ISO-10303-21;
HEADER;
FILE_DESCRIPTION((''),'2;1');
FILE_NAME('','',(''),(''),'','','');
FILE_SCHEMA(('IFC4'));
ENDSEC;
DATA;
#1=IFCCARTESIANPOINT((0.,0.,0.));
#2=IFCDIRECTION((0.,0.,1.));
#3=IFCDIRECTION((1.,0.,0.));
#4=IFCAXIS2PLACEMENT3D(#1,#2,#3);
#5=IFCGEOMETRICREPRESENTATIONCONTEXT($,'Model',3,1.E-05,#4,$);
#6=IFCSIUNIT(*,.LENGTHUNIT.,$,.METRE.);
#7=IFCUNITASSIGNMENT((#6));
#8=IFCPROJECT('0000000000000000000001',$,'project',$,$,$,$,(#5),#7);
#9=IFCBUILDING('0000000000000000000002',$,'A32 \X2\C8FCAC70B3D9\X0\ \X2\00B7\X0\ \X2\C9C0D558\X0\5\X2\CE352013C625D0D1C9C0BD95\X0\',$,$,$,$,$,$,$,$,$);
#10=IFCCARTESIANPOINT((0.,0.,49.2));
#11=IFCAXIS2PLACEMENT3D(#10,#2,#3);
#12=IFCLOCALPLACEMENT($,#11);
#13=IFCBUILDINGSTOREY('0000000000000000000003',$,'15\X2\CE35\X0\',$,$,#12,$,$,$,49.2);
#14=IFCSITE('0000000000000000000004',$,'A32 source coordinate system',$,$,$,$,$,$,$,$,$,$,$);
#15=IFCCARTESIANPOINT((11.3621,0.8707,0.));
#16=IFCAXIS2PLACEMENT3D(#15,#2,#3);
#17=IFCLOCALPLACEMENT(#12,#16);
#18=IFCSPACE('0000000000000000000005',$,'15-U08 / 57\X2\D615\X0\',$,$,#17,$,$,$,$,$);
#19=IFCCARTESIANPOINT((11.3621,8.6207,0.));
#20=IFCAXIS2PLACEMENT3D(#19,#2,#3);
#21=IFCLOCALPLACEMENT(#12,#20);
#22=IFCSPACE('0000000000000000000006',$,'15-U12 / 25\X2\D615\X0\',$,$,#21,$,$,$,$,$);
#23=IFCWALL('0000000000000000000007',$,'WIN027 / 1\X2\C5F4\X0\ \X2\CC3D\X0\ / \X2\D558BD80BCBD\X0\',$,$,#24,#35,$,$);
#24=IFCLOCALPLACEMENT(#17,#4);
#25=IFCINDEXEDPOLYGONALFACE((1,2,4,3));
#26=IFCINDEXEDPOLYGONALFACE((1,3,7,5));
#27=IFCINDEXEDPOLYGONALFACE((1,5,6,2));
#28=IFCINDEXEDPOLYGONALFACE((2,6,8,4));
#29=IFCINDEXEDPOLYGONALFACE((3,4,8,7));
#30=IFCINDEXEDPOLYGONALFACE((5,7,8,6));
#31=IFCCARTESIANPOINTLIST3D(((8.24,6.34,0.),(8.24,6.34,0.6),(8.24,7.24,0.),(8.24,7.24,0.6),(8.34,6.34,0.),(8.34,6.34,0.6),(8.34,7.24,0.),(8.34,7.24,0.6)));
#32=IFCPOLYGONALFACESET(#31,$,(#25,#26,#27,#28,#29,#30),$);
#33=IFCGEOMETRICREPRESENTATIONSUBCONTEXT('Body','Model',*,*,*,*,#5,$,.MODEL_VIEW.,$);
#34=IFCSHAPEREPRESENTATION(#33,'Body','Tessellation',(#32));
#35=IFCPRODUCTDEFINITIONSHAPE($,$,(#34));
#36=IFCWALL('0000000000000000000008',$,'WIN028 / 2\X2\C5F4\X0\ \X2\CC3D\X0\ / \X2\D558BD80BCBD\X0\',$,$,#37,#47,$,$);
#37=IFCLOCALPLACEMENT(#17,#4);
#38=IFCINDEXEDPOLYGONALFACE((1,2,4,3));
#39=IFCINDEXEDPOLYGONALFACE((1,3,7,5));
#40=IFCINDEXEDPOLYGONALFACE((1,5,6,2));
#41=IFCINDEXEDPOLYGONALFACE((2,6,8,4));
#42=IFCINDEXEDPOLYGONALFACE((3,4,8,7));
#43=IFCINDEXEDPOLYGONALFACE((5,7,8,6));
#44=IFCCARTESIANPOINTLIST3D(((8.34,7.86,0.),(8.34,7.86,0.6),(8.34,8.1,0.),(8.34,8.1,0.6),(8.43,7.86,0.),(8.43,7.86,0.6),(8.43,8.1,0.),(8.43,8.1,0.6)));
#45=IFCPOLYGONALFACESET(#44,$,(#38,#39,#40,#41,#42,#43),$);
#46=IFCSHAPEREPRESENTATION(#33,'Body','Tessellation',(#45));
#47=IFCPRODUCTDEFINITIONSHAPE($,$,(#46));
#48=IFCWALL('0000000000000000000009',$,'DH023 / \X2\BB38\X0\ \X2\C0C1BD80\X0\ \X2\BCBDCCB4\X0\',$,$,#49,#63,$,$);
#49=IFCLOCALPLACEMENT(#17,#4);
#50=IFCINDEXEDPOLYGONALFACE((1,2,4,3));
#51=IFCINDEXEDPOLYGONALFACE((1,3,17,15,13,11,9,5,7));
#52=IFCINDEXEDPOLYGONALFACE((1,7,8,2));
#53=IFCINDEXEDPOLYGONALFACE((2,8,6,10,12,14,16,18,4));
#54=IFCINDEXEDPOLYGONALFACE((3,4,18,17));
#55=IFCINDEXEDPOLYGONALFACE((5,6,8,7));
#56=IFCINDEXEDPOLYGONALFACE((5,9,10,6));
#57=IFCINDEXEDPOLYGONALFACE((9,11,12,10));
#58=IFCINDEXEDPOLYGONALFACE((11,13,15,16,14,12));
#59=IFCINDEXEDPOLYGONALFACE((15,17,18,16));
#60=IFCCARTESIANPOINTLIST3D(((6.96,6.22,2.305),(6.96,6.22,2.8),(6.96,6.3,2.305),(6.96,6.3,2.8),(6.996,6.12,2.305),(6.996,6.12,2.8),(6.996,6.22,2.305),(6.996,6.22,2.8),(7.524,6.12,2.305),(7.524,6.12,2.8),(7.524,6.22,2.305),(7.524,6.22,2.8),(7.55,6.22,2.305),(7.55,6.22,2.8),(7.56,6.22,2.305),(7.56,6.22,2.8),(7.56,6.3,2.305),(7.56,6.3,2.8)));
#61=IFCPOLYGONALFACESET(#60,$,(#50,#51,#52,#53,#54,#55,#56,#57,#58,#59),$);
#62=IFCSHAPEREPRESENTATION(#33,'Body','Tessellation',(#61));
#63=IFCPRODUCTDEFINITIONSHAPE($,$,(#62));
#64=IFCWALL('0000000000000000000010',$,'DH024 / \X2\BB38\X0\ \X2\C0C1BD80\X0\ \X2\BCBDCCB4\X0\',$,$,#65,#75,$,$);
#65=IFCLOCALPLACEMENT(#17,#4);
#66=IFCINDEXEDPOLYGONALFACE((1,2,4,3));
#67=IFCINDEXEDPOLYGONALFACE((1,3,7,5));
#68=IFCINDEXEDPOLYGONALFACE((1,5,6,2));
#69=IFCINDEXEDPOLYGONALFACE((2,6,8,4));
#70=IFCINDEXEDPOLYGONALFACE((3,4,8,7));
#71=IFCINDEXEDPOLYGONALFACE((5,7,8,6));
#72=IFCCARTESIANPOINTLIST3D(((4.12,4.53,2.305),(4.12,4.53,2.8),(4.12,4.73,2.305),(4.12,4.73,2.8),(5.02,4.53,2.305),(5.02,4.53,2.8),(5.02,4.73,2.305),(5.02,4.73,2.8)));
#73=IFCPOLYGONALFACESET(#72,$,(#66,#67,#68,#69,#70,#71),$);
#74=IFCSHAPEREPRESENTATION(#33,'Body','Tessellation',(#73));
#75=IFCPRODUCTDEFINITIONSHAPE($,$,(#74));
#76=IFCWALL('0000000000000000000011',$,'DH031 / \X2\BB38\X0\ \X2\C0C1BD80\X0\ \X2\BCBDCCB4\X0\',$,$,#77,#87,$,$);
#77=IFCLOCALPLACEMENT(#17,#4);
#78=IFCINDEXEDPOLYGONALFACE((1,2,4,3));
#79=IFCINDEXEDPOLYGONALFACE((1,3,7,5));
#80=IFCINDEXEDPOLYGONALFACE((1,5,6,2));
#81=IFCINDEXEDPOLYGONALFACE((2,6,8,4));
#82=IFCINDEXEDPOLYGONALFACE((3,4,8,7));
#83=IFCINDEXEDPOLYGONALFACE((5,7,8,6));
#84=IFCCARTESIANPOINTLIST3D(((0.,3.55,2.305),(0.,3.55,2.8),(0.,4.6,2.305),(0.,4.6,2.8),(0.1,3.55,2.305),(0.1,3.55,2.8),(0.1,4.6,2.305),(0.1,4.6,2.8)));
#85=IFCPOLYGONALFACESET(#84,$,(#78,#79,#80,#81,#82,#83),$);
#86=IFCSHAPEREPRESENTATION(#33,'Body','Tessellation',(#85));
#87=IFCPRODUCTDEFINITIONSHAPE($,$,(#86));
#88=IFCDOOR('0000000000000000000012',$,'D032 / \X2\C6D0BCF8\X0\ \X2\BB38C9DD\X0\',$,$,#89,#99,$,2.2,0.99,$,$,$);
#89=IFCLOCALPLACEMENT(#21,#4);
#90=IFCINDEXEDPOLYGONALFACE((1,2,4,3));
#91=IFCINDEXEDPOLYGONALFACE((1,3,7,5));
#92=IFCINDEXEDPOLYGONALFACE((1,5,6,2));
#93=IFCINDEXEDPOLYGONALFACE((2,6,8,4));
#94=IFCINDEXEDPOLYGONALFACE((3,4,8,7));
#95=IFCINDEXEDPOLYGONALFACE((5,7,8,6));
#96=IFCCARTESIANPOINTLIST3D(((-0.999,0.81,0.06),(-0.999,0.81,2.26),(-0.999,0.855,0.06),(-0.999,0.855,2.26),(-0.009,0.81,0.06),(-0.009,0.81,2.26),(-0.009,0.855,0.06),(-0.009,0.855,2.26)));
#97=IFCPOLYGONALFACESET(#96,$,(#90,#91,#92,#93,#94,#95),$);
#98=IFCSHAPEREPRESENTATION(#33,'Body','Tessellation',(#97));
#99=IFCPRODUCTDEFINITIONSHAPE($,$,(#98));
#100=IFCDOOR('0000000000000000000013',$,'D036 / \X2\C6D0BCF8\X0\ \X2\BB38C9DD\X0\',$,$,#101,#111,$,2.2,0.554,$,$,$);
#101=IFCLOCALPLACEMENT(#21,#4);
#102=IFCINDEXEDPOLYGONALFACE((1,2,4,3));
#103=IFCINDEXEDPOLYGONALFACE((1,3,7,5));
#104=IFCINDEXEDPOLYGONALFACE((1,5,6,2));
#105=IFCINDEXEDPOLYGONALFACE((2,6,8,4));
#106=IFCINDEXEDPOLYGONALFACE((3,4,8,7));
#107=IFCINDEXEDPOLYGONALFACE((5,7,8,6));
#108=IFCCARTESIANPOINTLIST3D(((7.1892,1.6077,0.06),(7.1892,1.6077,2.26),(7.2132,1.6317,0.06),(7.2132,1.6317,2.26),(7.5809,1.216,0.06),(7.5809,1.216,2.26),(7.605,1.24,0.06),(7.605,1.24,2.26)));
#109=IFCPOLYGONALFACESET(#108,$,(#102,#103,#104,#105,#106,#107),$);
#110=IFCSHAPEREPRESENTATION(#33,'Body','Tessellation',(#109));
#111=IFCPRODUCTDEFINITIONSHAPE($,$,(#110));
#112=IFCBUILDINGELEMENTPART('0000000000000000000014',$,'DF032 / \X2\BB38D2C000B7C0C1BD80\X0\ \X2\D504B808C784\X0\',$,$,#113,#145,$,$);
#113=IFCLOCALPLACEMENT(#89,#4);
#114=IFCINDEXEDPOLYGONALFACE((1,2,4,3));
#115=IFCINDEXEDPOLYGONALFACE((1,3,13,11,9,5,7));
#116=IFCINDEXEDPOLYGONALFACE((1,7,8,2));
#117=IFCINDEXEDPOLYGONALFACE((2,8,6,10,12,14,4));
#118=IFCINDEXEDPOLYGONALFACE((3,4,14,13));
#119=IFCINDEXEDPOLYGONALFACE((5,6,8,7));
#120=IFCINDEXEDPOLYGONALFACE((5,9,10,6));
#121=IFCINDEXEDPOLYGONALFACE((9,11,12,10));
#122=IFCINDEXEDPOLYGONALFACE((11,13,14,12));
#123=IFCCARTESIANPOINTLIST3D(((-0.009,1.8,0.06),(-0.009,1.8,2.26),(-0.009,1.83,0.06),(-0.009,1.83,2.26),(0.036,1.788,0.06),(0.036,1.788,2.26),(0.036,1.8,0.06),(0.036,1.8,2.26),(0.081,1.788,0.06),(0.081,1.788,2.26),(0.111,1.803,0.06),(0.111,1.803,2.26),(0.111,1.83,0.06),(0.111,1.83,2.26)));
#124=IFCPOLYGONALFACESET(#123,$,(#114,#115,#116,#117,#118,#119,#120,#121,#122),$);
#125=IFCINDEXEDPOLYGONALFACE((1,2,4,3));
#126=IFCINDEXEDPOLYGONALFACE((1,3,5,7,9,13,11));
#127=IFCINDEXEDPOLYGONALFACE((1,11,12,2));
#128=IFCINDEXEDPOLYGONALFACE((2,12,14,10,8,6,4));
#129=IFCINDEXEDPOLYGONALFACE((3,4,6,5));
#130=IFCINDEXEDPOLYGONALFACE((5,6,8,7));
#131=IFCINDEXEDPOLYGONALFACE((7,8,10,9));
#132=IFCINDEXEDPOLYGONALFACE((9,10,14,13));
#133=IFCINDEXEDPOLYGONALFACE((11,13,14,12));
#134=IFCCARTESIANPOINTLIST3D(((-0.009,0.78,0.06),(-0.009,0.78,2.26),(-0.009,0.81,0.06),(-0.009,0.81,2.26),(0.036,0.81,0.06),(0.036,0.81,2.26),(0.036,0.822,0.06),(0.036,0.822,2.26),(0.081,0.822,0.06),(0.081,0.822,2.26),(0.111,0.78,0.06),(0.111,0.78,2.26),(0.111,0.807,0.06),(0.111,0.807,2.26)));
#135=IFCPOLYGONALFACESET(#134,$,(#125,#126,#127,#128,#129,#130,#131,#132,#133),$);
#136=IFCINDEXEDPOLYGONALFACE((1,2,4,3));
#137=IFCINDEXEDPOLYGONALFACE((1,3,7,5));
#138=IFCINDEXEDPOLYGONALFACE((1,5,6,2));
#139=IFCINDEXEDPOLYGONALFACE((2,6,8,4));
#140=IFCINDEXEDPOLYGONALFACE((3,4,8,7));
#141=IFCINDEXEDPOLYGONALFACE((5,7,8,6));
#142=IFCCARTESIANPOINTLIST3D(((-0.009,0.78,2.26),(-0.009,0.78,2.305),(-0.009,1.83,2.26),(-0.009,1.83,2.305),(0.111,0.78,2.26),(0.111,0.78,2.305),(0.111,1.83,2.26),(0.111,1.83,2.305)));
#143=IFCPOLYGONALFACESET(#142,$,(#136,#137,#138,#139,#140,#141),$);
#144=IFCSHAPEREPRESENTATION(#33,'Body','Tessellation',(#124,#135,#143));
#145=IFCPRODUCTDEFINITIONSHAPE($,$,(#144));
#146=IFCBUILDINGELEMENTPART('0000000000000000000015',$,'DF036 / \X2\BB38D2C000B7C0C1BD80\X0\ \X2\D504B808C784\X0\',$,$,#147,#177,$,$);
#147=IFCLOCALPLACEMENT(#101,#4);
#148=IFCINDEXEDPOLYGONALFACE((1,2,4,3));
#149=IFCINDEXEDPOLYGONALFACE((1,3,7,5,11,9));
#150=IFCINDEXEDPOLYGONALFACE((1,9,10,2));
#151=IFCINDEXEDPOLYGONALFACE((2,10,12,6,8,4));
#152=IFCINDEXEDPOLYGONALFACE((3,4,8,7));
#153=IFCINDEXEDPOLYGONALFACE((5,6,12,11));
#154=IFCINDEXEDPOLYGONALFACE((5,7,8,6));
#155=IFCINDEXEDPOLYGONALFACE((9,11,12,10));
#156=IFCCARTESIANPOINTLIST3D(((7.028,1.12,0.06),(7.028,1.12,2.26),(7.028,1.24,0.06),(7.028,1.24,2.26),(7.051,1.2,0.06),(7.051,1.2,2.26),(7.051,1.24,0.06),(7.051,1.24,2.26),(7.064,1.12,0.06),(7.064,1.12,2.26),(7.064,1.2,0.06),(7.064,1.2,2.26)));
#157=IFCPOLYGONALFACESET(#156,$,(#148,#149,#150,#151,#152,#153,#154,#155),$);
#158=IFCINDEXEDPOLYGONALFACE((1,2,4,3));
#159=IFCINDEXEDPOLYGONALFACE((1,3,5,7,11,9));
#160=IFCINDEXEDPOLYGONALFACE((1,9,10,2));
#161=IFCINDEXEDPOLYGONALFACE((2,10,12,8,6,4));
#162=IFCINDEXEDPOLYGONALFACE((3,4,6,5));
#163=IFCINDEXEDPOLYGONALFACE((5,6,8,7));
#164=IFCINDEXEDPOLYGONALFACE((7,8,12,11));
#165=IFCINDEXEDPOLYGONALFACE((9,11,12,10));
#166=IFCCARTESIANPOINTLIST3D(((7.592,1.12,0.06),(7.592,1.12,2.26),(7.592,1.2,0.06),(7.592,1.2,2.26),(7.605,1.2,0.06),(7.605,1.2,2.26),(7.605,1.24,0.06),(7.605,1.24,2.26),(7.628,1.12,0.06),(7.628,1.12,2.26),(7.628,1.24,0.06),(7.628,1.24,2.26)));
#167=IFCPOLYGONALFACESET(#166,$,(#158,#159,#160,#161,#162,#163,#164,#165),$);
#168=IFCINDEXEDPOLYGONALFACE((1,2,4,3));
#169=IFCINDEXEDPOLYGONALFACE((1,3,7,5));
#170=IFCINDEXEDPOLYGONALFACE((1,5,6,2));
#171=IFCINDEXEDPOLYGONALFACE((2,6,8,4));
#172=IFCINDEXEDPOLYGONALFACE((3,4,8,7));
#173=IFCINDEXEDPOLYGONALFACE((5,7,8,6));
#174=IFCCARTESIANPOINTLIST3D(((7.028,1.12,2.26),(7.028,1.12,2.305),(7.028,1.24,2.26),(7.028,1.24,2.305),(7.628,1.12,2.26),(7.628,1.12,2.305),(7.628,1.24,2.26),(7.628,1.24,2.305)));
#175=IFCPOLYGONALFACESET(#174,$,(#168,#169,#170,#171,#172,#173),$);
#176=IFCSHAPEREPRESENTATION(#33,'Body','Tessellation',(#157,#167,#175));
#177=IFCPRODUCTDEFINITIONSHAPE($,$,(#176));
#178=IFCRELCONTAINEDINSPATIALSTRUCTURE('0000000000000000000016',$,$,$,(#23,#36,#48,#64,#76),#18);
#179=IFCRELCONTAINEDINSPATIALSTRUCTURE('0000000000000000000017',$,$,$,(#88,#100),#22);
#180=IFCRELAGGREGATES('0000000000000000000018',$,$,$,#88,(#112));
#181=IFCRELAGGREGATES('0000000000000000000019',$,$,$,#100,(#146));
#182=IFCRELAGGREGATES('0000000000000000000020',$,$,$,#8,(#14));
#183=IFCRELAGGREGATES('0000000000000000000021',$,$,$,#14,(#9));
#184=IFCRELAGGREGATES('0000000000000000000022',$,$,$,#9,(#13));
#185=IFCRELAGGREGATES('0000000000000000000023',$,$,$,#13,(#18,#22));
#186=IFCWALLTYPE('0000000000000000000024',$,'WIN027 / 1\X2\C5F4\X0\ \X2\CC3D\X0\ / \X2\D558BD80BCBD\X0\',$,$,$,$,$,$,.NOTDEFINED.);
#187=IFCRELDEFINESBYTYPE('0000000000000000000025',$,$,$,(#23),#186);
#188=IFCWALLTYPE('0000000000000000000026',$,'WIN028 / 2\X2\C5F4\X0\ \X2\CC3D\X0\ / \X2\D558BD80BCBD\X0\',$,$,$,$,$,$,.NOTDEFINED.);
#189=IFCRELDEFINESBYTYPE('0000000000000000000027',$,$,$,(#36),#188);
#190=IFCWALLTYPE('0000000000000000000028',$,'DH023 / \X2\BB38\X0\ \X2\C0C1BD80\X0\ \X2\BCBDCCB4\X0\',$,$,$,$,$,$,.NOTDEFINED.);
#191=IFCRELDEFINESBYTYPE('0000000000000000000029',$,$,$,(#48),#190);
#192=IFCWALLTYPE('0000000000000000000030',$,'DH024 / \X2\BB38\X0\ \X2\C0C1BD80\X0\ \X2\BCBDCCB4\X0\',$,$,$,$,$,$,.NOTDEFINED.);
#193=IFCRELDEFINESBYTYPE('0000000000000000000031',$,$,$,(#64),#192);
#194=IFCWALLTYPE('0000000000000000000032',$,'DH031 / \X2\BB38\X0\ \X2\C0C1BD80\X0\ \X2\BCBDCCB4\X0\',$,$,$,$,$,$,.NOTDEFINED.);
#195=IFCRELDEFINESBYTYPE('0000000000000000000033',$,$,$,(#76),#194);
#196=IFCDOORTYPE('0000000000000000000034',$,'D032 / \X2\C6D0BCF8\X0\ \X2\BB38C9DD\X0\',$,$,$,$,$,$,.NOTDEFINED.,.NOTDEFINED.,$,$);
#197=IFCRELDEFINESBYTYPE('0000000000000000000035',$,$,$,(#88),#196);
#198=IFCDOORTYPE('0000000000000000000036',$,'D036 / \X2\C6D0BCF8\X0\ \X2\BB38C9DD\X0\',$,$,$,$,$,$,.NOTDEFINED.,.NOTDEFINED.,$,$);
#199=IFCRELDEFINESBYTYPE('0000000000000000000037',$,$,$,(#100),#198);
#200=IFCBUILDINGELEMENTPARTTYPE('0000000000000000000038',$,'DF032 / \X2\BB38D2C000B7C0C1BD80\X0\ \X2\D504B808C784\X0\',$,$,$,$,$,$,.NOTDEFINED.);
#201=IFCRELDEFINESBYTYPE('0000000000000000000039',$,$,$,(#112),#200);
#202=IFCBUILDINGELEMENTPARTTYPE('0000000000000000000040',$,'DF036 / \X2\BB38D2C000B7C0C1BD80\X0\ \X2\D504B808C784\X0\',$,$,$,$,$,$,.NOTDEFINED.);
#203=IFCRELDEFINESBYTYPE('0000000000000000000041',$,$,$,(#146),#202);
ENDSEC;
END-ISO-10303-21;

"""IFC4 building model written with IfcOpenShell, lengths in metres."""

from ifc_helpers import new_model, si_unit, frame, origin, origin_with_axes, place, context, subcontext, project, spatial, polyline, outline, extrude, source, transform, mapped, type_object, type_shapes, element, aggregate, save


model = new_model("IFC4")

# Units and contexts
model_context = context("Model", 3, precision=1e-05, world=origin_with_axes())
body_context = subcontext(model_context, "Body", "Model", "MODEL_VIEW")
ifc_project = project(units=[si_unit("LENGTHUNIT", "METRE")], contexts=[model_context])

# Site, building, storey, space
storey_placement = place(None, frame((0.0, 0.0, 49.2), z_axis=(0.0, 0.0, 1.0), x_axis=(1.0, 0.0, 0.0)))
space_1_placement = place(storey_placement, frame((11.3621, 8.6207, 0.0), z_axis=(0.0, 0.0, 1.0), x_axis=(1.0, 0.0, 0.0)))
site = spatial("IfcSite", under=ifc_project, Name="A32 source coordinate system")
building = spatial("IfcBuilding", under=site, Name="A32 주거동 · 지하5층–옥탑지붕")
storey = spatial("IfcBuildingStorey", under=building, at=storey_placement, Name="15층", Elevation=49.2)
space_2_placement = place(storey_placement, frame((11.3621, 0.8707, 0.0), z_axis=(0.0, 0.0, 1.0), x_axis=(1.0, 0.0, 0.0)))
space_2 = spatial("IfcSpace", under=storey, at=space_2_placement, Name="15-U08 / 57형")

# Walls
wall_type_1 = type_object("IfcWallType", Name="WIN027 / 1열 창 / 하부벽", PredefinedType="NOTDEFINED")
shared_shape_1 = source(origin(), body_context, "Body", "SweptSolid", [
    extrude(outline(polyline([(8.24, 6.34), (8.24, 7.24), (8.34, 7.24), (8.34, 6.34), (8.24, 6.34)])), origin(), (0.0, 0.0, 1.0), 0.6),
])
type_shapes(wall_type_1, [shared_shape_1])
wall_1_placement = place(space_2_placement, origin_with_axes())
element("IfcWall", 1, at=wall_1_placement, inside=space_2, type_object=wall_type_1, Name="WIN027 / 1열 창 / 하부벽", context=body_context, shape_type="MappedRepresentation", body=[
    mapped(shared_shape_1, transform((0.0, 0.0, 0.0), scale=1.0)),
])
wall_type_2 = type_object("IfcWallType", Name="WIN028 / 2열 창 / 하부벽", PredefinedType="NOTDEFINED")
shared_shape_2 = source(origin(), body_context, "Body", "SweptSolid", [
    extrude(outline(polyline([(8.34, 7.86), (8.34, 8.1), (8.43, 8.1), (8.43, 7.86), (8.34, 7.86)])), origin(), (0.0, 0.0, 1.0), 0.6),
])
type_shapes(wall_type_2, [shared_shape_2])
wall_2_placement = place(space_2_placement, origin_with_axes())
element("IfcWall", 2, at=wall_2_placement, inside=space_2, type_object=wall_type_2, Name="WIN028 / 2열 창 / 하부벽", context=body_context, shape_type="MappedRepresentation", body=[
    mapped(shared_shape_2, transform((0.0, 0.0, 0.0), scale=1.0)),
])
wall_type_3 = type_object("IfcWallType", Name="DH023 / 문 상부 벽체", PredefinedType="NOTDEFINED")
shared_shape_3 = source(origin(), body_context, "Body", "SweptSolid", [
    extrude(outline(polyline([(6.96, 6.3), (7.56, 6.3), (7.56, 6.22), (7.55, 6.22), (7.524, 6.22), (7.524, 6.12), (6.996, 6.12), (6.996, 6.22), (6.96, 6.22), (6.96, 6.3)])), frame((0.0, 0.0, 2.305)), (0.0, 0.0, 1.0), 0.495),
])
type_shapes(wall_type_3, [shared_shape_3])
wall_3_placement = place(space_2_placement, origin_with_axes())
element("IfcWall", 3, at=wall_3_placement, inside=space_2, type_object=wall_type_3, Name="DH023 / 문 상부 벽체", context=body_context, shape_type="MappedRepresentation", body=[
    mapped(shared_shape_3, transform((0.0, 0.0, 0.0), scale=1.0)),
])
wall_type_4 = type_object("IfcWallType", Name="DH024 / 문 상부 벽체", PredefinedType="NOTDEFINED")
shared_shape_4 = source(origin(), body_context, "Body", "SweptSolid", [
    extrude(outline(polyline([(4.12, 4.73), (5.02, 4.73), (5.02, 4.53), (4.12, 4.53), (4.12, 4.73)])), frame((0.0, 0.0, 2.305)), (0.0, 0.0, 1.0), 0.495),
])
type_shapes(wall_type_4, [shared_shape_4])
wall_4_placement = place(space_2_placement, origin_with_axes())
element("IfcWall", 4, at=wall_4_placement, inside=space_2, type_object=wall_type_4, Name="DH024 / 문 상부 벽체", context=body_context, shape_type="MappedRepresentation", body=[
    mapped(shared_shape_4, transform((0.0, 0.0, 0.0), scale=1.0)),
])
wall_type_5 = type_object("IfcWallType", Name="DH031 / 문 상부 벽체", PredefinedType="NOTDEFINED")
shared_shape_5 = source(origin(), body_context, "Body", "SweptSolid", [
    extrude(outline(polyline([(0.0, 4.6), (0.1, 4.6), (0.1, 3.55), (0.0, 3.55), (0.0, 4.6)])), frame((0.0, 0.0, 2.305)), (0.0, 0.0, 1.0), 0.495),
])
type_shapes(wall_type_5, [shared_shape_5])
wall_5_placement = place(space_2_placement, origin_with_axes())
element("IfcWall", 5, at=wall_5_placement, inside=space_2, type_object=wall_type_5, Name="DH031 / 문 상부 벽체", context=body_context, shape_type="MappedRepresentation", body=[
    mapped(shared_shape_5, transform((0.0, 0.0, 0.0), scale=1.0)),
])

# Shared definitions
space_1 = spatial("IfcSpace", under=storey, at=space_1_placement, Name="15-U12 / 25형")

# Doors
door_type_1 = type_object("IfcDoorType", Name="D032 / 원본 문짝", OperationType="NOTDEFINED", PredefinedType="NOTDEFINED")
shared_shape_6 = source(origin(), body_context, "Body", "SweptSolid", [
    extrude(outline(polyline([(-0.009, 0.81), (-0.999, 0.81), (-0.999, 0.855), (-0.009, 0.855), (-0.009, 0.81)])), frame((0.0, 0.0, 0.06)), (0.0, 0.0, 1.0), 2.2),
])
type_shapes(door_type_1, [shared_shape_6])
door_1_placement = place(space_1_placement, origin_with_axes())
door_1 = element("IfcDoor", 6, at=door_1_placement, inside=space_1, type_object=door_type_1, Name="D032 / 원본 문짝", OverallHeight=2.2, OverallWidth=0.99, context=body_context, shape_type="MappedRepresentation", body=[
    mapped(shared_shape_6, transform((0.0, 0.0, 0.0), scale=1.0)),
])
door_type_2 = type_object("IfcDoorType", Name="D036 / 원본 문짝", OperationType="NOTDEFINED", PredefinedType="NOTDEFINED")
shared_shape_7 = source(origin(), body_context, "Body", "SweptSolid", [
    extrude(outline(polyline([(7.1892, 1.6077), (7.2132, 1.6317), (7.605, 1.24), (7.5809, 1.216), (7.1892, 1.6077)])), frame((0.0, 0.0, 0.06)), (0.0, 0.0, 1.0), 2.2),
])
type_shapes(door_type_2, [shared_shape_7])
door_2_placement = place(space_1_placement, origin_with_axes())
door_2 = element("IfcDoor", 7, at=door_2_placement, inside=space_1, type_object=door_type_2, Name="D036 / 원본 문짝", OverallHeight=2.2, OverallWidth=0.554, context=body_context, shape_type="MappedRepresentation", body=[
    mapped(shared_shape_7, transform((0.0, 0.0, 0.0), scale=1.0)),
])

# Building element parts
building_element_part_type_1 = type_object("IfcBuildingElementPartType", Name="DF032 / 문틀·상부 프레임", PredefinedType="NOTDEFINED")
shared_shape_8 = source(origin(), body_context, "Body", "SweptSolid", [
    extrude(outline(polyline([(0.111, 1.83), (0.111, 1.803), (0.081, 1.788), (0.036, 1.788), (0.036, 1.8), (-0.009, 1.8), (-0.009, 1.83), (0.111, 1.83)])), frame((0.0, 0.0, 0.06)), (0.0, 0.0, 1.0), 2.2),
    extrude(outline(polyline([(-0.009, 0.81), (0.036, 0.81), (0.036, 0.822), (0.081, 0.822), (0.111, 0.807), (0.111, 0.78), (-0.009, 0.78), (-0.009, 0.81)])), frame((0.0, 0.0, 0.06)), (0.0, 0.0, 1.0), 2.2),
    extrude(outline(polyline([(-0.009, 0.78), (-0.009, 1.83), (0.111, 1.83), (0.111, 0.78), (-0.009, 0.78)])), frame((0.0, 0.0, 2.26)), (0.0, 0.0, 1.0), 0.045),
])
type_shapes(building_element_part_type_1, [shared_shape_8])
building_element_part_1_placement = place(door_1_placement, origin_with_axes())
building_element_part_1 = element("IfcBuildingElementPart", 8, at=building_element_part_1_placement, type_object=building_element_part_type_1, Name="DF032 / 문틀·상부 프레임", context=body_context, shape_type="MappedRepresentation", body=[
    mapped(shared_shape_8, transform((0.0, 0.0, 0.0), scale=1.0)),
])
aggregate(door_1, [building_element_part_1])
building_element_part_type_2 = type_object("IfcBuildingElementPartType", Name="DF036 / 문틀·상부 프레임", PredefinedType="NOTDEFINED")
shared_shape_9 = source(origin(), body_context, "Body", "SweptSolid", [
    extrude(outline(polyline([(7.028, 1.24), (7.051, 1.24), (7.051, 1.2), (7.064, 1.2), (7.064, 1.12), (7.028, 1.12), (7.028, 1.24)])), frame((0.0, 0.0, 0.06)), (0.0, 0.0, 1.0), 2.2),
    extrude(outline(polyline([(7.592, 1.12), (7.592, 1.2), (7.605, 1.2), (7.605, 1.24), (7.628, 1.24), (7.628, 1.12), (7.592, 1.12)])), frame((0.0, 0.0, 0.06)), (0.0, 0.0, 1.0), 2.2),
    extrude(outline(polyline([(7.028, 1.12), (7.028, 1.24), (7.628, 1.24), (7.628, 1.12), (7.028, 1.12)])), frame((0.0, 0.0, 2.26)), (0.0, 0.0, 1.0), 0.045),
])
type_shapes(building_element_part_type_2, [shared_shape_9])
building_element_part_2_placement = place(door_2_placement, origin_with_axes())
building_element_part_2 = element("IfcBuildingElementPart", 9, at=building_element_part_2_placement, type_object=building_element_part_type_2, Name="DF036 / 문틀·상부 프레임", context=body_context, shape_type="MappedRepresentation", body=[
    mapped(shared_shape_9, transform((0.0, 0.0, 0.0), scale=1.0)),
])
aggregate(door_2, [building_element_part_2])

save(model, "model.ifc")
